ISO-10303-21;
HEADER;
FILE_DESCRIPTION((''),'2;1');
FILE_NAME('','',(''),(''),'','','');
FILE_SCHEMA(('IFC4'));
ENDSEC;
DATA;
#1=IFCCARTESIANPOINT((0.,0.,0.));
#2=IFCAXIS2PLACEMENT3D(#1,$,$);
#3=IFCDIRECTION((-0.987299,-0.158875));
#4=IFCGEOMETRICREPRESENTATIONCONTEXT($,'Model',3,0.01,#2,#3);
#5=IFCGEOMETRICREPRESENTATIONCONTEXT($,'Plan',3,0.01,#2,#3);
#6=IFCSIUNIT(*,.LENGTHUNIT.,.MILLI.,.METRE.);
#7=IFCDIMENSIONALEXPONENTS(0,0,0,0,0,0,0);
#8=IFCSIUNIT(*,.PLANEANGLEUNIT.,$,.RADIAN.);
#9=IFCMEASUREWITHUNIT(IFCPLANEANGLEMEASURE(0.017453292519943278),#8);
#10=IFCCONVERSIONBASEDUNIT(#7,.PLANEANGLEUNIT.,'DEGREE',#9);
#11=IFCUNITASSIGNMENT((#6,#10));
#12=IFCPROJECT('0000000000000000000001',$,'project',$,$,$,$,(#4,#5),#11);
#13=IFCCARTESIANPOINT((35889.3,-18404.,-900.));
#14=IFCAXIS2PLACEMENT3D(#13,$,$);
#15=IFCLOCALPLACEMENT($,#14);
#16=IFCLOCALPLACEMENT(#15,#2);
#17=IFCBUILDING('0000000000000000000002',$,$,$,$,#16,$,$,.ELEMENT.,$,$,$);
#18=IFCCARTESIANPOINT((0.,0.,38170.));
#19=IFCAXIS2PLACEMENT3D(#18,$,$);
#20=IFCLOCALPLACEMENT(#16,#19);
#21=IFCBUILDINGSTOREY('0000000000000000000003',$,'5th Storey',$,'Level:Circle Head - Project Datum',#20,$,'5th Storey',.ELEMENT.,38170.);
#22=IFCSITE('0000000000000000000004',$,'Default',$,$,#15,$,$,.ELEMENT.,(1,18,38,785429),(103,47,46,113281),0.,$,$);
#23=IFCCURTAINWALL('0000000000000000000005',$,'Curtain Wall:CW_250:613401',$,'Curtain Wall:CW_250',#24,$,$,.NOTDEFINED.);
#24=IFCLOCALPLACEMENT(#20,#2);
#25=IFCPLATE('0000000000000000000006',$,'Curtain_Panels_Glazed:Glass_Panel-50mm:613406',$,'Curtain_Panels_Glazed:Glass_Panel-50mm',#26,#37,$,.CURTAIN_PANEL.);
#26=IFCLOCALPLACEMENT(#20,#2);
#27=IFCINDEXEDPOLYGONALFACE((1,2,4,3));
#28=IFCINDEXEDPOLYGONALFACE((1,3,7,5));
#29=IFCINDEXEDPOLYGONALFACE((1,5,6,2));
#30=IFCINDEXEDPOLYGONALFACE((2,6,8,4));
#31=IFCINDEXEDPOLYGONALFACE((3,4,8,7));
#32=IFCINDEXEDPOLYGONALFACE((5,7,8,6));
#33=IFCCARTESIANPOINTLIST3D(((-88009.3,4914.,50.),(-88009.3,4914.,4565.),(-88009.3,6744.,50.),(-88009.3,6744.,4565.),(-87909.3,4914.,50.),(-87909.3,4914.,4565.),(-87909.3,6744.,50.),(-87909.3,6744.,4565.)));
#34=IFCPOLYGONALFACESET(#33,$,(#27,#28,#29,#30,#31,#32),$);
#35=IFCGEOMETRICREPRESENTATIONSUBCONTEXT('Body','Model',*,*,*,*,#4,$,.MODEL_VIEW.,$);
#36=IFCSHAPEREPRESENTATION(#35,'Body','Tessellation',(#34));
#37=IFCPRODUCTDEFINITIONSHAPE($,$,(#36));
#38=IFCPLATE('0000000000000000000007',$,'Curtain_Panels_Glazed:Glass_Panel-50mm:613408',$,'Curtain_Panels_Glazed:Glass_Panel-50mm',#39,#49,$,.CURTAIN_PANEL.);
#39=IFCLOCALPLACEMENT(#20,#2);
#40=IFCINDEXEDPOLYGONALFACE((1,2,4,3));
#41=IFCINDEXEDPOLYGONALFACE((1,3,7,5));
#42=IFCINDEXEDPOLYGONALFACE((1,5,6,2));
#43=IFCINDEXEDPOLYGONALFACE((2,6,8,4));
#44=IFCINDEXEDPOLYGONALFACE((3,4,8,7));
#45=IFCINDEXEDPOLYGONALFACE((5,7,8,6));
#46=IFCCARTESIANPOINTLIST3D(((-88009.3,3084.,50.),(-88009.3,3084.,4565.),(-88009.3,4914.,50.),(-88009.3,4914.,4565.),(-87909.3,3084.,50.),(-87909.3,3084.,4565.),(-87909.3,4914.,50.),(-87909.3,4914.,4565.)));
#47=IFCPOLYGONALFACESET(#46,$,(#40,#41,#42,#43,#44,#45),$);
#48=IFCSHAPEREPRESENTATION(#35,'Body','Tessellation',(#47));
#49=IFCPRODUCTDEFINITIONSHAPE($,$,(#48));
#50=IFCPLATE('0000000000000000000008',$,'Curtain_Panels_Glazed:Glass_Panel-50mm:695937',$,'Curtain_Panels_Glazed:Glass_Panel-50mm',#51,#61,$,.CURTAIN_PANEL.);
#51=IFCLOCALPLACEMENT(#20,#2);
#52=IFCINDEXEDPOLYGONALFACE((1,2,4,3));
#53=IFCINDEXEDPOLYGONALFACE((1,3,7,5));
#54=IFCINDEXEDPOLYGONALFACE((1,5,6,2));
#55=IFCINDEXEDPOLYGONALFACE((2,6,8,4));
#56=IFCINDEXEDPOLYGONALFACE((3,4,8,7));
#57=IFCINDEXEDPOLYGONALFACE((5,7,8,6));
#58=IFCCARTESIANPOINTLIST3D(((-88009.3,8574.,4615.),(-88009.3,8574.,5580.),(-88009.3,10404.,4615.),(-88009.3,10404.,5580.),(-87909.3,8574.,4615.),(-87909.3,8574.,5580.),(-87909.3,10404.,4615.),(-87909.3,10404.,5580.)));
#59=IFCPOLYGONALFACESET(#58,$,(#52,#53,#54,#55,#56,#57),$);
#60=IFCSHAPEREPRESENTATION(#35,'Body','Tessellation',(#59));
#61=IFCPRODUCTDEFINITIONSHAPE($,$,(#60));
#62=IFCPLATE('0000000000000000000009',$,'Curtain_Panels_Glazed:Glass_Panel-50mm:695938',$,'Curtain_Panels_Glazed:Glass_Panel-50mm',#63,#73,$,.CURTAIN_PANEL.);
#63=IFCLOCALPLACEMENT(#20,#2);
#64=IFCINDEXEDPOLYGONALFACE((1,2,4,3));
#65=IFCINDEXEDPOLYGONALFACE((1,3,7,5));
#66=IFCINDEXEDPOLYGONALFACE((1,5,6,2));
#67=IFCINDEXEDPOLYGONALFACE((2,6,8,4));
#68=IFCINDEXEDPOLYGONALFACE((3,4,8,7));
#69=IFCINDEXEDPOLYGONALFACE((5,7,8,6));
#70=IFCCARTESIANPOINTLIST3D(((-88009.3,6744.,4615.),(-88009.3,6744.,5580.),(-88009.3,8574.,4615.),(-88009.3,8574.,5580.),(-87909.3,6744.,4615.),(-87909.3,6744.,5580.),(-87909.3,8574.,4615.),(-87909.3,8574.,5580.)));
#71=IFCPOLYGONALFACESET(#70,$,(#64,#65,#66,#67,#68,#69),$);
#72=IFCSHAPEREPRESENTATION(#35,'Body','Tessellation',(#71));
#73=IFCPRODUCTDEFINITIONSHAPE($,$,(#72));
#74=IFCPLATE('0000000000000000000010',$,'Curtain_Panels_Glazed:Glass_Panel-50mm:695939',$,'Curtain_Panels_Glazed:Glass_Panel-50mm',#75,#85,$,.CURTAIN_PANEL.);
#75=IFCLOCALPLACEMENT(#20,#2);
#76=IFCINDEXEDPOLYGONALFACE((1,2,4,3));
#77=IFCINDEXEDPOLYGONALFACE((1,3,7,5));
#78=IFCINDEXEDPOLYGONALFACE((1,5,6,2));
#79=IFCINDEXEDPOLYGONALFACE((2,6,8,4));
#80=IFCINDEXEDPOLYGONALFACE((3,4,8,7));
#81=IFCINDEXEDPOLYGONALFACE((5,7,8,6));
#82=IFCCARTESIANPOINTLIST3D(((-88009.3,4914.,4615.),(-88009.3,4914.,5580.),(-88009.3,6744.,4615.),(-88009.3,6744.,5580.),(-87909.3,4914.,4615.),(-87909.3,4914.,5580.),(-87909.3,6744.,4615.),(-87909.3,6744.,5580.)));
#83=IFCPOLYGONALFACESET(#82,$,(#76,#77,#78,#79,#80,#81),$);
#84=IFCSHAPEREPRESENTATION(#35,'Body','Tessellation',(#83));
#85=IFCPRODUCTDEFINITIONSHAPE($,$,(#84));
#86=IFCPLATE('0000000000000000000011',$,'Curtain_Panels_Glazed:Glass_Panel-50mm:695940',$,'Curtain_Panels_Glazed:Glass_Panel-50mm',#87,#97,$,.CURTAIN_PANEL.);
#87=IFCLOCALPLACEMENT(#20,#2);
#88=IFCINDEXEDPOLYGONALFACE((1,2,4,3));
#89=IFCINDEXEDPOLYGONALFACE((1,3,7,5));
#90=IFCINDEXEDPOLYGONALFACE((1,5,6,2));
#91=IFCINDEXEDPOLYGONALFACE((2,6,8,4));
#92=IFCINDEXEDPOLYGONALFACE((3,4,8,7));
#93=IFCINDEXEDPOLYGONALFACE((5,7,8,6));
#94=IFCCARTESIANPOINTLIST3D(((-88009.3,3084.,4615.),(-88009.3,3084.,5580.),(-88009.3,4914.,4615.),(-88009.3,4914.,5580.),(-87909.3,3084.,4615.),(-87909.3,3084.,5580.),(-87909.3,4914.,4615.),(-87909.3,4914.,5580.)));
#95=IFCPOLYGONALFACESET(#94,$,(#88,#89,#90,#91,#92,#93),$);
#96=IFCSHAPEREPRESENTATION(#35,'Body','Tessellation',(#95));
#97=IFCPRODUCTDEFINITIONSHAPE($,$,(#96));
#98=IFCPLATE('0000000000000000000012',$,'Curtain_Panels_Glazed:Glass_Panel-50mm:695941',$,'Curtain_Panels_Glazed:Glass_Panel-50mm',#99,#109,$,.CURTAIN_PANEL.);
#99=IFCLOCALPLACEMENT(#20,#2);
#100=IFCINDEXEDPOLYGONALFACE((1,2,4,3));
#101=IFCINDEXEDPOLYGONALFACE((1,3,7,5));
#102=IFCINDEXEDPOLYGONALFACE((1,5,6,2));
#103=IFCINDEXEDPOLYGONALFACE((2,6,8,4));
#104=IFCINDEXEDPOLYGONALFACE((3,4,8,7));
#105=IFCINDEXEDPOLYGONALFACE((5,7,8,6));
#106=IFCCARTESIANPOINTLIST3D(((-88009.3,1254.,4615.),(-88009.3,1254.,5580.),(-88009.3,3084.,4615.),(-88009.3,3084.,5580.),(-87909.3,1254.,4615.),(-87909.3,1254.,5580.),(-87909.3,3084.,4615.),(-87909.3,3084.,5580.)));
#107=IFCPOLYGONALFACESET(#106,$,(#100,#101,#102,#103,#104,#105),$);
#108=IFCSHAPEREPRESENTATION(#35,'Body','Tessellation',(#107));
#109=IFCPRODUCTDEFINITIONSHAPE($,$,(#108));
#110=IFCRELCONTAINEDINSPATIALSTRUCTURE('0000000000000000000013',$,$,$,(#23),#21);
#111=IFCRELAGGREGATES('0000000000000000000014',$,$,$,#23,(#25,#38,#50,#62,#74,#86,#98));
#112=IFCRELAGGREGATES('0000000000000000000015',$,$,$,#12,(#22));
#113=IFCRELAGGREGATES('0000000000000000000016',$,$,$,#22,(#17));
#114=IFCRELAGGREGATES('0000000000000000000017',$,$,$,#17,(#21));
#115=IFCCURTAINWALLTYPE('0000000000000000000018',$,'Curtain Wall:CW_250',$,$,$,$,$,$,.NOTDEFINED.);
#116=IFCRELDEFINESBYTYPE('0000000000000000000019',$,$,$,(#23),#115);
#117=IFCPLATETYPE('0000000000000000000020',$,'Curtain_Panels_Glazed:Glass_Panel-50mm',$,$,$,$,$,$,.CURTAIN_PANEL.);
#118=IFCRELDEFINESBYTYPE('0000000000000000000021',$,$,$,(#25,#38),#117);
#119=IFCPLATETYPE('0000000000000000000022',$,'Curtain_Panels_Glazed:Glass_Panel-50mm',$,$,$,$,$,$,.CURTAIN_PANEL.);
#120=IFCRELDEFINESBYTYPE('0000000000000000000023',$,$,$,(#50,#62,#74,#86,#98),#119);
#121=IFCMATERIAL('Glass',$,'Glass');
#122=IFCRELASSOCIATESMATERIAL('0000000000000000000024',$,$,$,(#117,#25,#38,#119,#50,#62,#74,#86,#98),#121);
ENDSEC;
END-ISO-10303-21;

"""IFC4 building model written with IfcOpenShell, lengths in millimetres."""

from ifc_helpers import new_model, entity, si_unit, converted_unit, direction, frame, origin, place, context, subcontext, project, spatial, indexed_curve, outline, extrude, source, transform, mapped, material, type_object, type_shapes, element, aggregate, save


model = new_model("IFC4")

# Units and contexts
model_context = context("Model", 3, precision=0.01, world=origin(), true_north=direction((-0.987299, -0.158875)))
plan_context = context("Plan", 3, precision=0.01, world=origin(), true_north=direction((-0.987299, -0.158875)))
body_context = subcontext(model_context, "Body", "Model", "MODEL_VIEW")
ifc_project = project(units=[si_unit("LENGTHUNIT", "METRE", prefix="MILLI"), converted_unit("PLANEANGLEUNIT", "DEGREE", entity("IfcPlaneAngleMeasure", 0.017453292519943278), si_unit("PLANEANGLEUNIT", "RADIAN"), dimensions=[0, 0, 0, 0, 0, 0, 0])], contexts=[model_context, plan_context])

# Site, building, storey
site_placement = place(None, frame((35889.3, -18404.0, -900.0)))
site = spatial("IfcSite", under=ifc_project, at=site_placement, Name="Default", CompositionType="ELEMENT", RefLatitude=(1, 18, 38, 785429), RefLongitude=(103, 47, 46, 113281), RefElevation=0.0)
building_placement = place(site_placement, origin())
building = spatial("IfcBuilding", under=site, at=building_placement, CompositionType="ELEMENT")
storey_placement = place(building_placement, frame((0.0, 0.0, 38170.0)))
storey = spatial("IfcBuildingStorey", under=building, at=storey_placement, Name="5th Storey", ObjectType="Level:Circle Head - Project Datum", LongName="5th Storey", CompositionType="ELEMENT", Elevation=38170.0)

# Curtain wall
curtain_wall_type = type_object("IfcCurtainWallType", Name="Curtain Wall:CW_250", PredefinedType="NOTDEFINED")
curtain_wall_1_placement = place(storey_placement, frame((0.0, 0.0, -38170.0)))
curtain_wall_1 = element("IfcCurtainWall", 1, at=curtain_wall_1_placement, inside=storey, type_object=curtain_wall_type, Name="Curtain Wall:CW_250:613401", ObjectType="Curtain Wall:CW_250", PredefinedType="NOTDEFINED")

# Plates
ifc_material_1 = material(Name="Glass", Category="Glass")
plate_type_1 = type_object("IfcPlateType", Name="Curtain_Panels_Glazed:Glass_Panel-50mm", PredefinedType="CURTAIN_PANEL", material=ifc_material_1)
shared_shape_1 = source(origin(), body_context, "Body", "SweptSolid", [
    extrude(outline(indexed_curve([(-50.0, -915.0), (50.0, -915.0), (50.0, 915.0), (-50.0, 915.0), (-50.0, -915.0)], self_intersect=False)), frame((0.0, 200.0, 0.0), z_axis=(0.0, 0.0, 1.0), x_axis=(0.0, 1.0, 0.0)), (0.0, 0.0, 1.0), 4515.0),
])
type_shapes(plate_type_1, [shared_shape_1])
plate_1_placement = place(curtain_wall_1_placement, frame((-88159.3, 5829.0, 38220.0), z_axis=(0.0, 0.0, 1.0), x_axis=(0.0, -1.0, 0.0)))
plate_1 = element("IfcPlate", 2, at=plate_1_placement, type_object=plate_type_1, material=ifc_material_1, Name="Curtain_Panels_Glazed:Glass_Panel-50mm:613406", ObjectType="Curtain_Panels_Glazed:Glass_Panel-50mm", PredefinedType="CURTAIN_PANEL", context=body_context, shape_type="MappedRepresentation", body=[
    mapped(shared_shape_1, transform((0.0, 0.0, 0.0), scale=1.0)),
])
plate_2_placement = place(curtain_wall_1_placement, frame((-88159.3, 3999.0, 38220.0), z_axis=(0.0, 0.0, 1.0), x_axis=(0.0, -1.0, 0.0)))
plate_2 = element("IfcPlate", 3, at=plate_2_placement, type_object=plate_type_1, material=ifc_material_1, Name="Curtain_Panels_Glazed:Glass_Panel-50mm:613408", ObjectType="Curtain_Panels_Glazed:Glass_Panel-50mm", PredefinedType="CURTAIN_PANEL", context=body_context, shape_type="MappedRepresentation", body=[
    mapped(shared_shape_1, transform((0.0, 0.0, 0.0), scale=1.0)),
])
plate_type_2 = type_object("IfcPlateType", Name="Curtain_Panels_Glazed:Glass_Panel-50mm", PredefinedType="CURTAIN_PANEL", material=ifc_material_1)
shared_shape_2 = source(origin(), body_context, "Body", "SweptSolid", [
    extrude(outline(indexed_curve([(-50.0, -915.0), (50.0, -915.0), (50.0, 915.0), (-50.0, 915.0), (-50.0, -915.0)], self_intersect=False)), frame((0.0, 200.0, 0.0), z_axis=(0.0, 0.0, 1.0), x_axis=(0.0, 1.0, 0.0)), (0.0, 0.0, 1.0), 965.0),
])
type_shapes(plate_type_2, [shared_shape_2])
plate_3_placement = place(curtain_wall_1_placement, frame((-88159.3, 9489.0, 42785.0), z_axis=(0.0, 0.0, 1.0), x_axis=(0.0, -1.0, 0.0)))
plate_3 = element("IfcPlate", 4, at=plate_3_placement, type_object=plate_type_2, material=ifc_material_1, Name="Curtain_Panels_Glazed:Glass_Panel-50mm:695937", ObjectType="Curtain_Panels_Glazed:Glass_Panel-50mm", PredefinedType="CURTAIN_PANEL", context=body_context, shape_type="MappedRepresentation", body=[
    mapped(shared_shape_2, transform((0.0, 0.0, 0.0), scale=1.0)),
])
plate_4_placement = place(curtain_wall_1_placement, frame((-88159.3, 7659.0, 42785.0), z_axis=(0.0, 0.0, 1.0), x_axis=(0.0, -1.0, 0.0)))
plate_4 = element("IfcPlate", 5, at=plate_4_placement, type_object=plate_type_2, material=ifc_material_1, Name="Curtain_Panels_Glazed:Glass_Panel-50mm:695938", ObjectType="Curtain_Panels_Glazed:Glass_Panel-50mm", PredefinedType="CURTAIN_PANEL", context=body_context, shape_type="MappedRepresentation", body=[
    mapped(shared_shape_2, transform((0.0, 0.0, 0.0), scale=1.0)),
])
plate_5_placement = place(curtain_wall_1_placement, frame((-88159.3, 5829.0, 42785.0), z_axis=(0.0, 0.0, 1.0), x_axis=(0.0, -1.0, 0.0)))
plate_5 = element("IfcPlate", 6, at=plate_5_placement, type_object=plate_type_2, material=ifc_material_1, Name="Curtain_Panels_Glazed:Glass_Panel-50mm:695939", ObjectType="Curtain_Panels_Glazed:Glass_Panel-50mm", PredefinedType="CURTAIN_PANEL", context=body_context, shape_type="MappedRepresentation", body=[
    mapped(shared_shape_2, transform((0.0, 0.0, 0.0), scale=1.0)),
])
plate_6_placement = place(curtain_wall_1_placement, frame((-88159.3, 3999.0, 42785.0), z_axis=(0.0, 0.0, 1.0), x_axis=(0.0, -1.0, 0.0)))
plate_6 = element("IfcPlate", 7, at=plate_6_placement, type_object=plate_type_2, material=ifc_material_1, Name="Curtain_Panels_Glazed:Glass_Panel-50mm:695940", ObjectType="Curtain_Panels_Glazed:Glass_Panel-50mm", PredefinedType="CURTAIN_PANEL", context=body_context, shape_type="MappedRepresentation", body=[
    mapped(shared_shape_2, transform((0.0, 0.0, 0.0), scale=1.0)),
])
plate_7_placement = place(curtain_wall_1_placement, frame((-88159.3, 2169.0, 42785.0), z_axis=(0.0, 0.0, 1.0), x_axis=(0.0, -1.0, 0.0)))
plate_7 = element("IfcPlate", 8, at=plate_7_placement, type_object=plate_type_2, material=ifc_material_1, Name="Curtain_Panels_Glazed:Glass_Panel-50mm:695941", ObjectType="Curtain_Panels_Glazed:Glass_Panel-50mm", PredefinedType="CURTAIN_PANEL", context=body_context, shape_type="MappedRepresentation", body=[
    mapped(shared_shape_2, transform((0.0, 0.0, 0.0), scale=1.0)),
])
aggregate(curtain_wall_1, [plate_1, plate_2, plate_3, plate_4, plate_5, plate_6, plate_7])

save(model, "model.ifc")
